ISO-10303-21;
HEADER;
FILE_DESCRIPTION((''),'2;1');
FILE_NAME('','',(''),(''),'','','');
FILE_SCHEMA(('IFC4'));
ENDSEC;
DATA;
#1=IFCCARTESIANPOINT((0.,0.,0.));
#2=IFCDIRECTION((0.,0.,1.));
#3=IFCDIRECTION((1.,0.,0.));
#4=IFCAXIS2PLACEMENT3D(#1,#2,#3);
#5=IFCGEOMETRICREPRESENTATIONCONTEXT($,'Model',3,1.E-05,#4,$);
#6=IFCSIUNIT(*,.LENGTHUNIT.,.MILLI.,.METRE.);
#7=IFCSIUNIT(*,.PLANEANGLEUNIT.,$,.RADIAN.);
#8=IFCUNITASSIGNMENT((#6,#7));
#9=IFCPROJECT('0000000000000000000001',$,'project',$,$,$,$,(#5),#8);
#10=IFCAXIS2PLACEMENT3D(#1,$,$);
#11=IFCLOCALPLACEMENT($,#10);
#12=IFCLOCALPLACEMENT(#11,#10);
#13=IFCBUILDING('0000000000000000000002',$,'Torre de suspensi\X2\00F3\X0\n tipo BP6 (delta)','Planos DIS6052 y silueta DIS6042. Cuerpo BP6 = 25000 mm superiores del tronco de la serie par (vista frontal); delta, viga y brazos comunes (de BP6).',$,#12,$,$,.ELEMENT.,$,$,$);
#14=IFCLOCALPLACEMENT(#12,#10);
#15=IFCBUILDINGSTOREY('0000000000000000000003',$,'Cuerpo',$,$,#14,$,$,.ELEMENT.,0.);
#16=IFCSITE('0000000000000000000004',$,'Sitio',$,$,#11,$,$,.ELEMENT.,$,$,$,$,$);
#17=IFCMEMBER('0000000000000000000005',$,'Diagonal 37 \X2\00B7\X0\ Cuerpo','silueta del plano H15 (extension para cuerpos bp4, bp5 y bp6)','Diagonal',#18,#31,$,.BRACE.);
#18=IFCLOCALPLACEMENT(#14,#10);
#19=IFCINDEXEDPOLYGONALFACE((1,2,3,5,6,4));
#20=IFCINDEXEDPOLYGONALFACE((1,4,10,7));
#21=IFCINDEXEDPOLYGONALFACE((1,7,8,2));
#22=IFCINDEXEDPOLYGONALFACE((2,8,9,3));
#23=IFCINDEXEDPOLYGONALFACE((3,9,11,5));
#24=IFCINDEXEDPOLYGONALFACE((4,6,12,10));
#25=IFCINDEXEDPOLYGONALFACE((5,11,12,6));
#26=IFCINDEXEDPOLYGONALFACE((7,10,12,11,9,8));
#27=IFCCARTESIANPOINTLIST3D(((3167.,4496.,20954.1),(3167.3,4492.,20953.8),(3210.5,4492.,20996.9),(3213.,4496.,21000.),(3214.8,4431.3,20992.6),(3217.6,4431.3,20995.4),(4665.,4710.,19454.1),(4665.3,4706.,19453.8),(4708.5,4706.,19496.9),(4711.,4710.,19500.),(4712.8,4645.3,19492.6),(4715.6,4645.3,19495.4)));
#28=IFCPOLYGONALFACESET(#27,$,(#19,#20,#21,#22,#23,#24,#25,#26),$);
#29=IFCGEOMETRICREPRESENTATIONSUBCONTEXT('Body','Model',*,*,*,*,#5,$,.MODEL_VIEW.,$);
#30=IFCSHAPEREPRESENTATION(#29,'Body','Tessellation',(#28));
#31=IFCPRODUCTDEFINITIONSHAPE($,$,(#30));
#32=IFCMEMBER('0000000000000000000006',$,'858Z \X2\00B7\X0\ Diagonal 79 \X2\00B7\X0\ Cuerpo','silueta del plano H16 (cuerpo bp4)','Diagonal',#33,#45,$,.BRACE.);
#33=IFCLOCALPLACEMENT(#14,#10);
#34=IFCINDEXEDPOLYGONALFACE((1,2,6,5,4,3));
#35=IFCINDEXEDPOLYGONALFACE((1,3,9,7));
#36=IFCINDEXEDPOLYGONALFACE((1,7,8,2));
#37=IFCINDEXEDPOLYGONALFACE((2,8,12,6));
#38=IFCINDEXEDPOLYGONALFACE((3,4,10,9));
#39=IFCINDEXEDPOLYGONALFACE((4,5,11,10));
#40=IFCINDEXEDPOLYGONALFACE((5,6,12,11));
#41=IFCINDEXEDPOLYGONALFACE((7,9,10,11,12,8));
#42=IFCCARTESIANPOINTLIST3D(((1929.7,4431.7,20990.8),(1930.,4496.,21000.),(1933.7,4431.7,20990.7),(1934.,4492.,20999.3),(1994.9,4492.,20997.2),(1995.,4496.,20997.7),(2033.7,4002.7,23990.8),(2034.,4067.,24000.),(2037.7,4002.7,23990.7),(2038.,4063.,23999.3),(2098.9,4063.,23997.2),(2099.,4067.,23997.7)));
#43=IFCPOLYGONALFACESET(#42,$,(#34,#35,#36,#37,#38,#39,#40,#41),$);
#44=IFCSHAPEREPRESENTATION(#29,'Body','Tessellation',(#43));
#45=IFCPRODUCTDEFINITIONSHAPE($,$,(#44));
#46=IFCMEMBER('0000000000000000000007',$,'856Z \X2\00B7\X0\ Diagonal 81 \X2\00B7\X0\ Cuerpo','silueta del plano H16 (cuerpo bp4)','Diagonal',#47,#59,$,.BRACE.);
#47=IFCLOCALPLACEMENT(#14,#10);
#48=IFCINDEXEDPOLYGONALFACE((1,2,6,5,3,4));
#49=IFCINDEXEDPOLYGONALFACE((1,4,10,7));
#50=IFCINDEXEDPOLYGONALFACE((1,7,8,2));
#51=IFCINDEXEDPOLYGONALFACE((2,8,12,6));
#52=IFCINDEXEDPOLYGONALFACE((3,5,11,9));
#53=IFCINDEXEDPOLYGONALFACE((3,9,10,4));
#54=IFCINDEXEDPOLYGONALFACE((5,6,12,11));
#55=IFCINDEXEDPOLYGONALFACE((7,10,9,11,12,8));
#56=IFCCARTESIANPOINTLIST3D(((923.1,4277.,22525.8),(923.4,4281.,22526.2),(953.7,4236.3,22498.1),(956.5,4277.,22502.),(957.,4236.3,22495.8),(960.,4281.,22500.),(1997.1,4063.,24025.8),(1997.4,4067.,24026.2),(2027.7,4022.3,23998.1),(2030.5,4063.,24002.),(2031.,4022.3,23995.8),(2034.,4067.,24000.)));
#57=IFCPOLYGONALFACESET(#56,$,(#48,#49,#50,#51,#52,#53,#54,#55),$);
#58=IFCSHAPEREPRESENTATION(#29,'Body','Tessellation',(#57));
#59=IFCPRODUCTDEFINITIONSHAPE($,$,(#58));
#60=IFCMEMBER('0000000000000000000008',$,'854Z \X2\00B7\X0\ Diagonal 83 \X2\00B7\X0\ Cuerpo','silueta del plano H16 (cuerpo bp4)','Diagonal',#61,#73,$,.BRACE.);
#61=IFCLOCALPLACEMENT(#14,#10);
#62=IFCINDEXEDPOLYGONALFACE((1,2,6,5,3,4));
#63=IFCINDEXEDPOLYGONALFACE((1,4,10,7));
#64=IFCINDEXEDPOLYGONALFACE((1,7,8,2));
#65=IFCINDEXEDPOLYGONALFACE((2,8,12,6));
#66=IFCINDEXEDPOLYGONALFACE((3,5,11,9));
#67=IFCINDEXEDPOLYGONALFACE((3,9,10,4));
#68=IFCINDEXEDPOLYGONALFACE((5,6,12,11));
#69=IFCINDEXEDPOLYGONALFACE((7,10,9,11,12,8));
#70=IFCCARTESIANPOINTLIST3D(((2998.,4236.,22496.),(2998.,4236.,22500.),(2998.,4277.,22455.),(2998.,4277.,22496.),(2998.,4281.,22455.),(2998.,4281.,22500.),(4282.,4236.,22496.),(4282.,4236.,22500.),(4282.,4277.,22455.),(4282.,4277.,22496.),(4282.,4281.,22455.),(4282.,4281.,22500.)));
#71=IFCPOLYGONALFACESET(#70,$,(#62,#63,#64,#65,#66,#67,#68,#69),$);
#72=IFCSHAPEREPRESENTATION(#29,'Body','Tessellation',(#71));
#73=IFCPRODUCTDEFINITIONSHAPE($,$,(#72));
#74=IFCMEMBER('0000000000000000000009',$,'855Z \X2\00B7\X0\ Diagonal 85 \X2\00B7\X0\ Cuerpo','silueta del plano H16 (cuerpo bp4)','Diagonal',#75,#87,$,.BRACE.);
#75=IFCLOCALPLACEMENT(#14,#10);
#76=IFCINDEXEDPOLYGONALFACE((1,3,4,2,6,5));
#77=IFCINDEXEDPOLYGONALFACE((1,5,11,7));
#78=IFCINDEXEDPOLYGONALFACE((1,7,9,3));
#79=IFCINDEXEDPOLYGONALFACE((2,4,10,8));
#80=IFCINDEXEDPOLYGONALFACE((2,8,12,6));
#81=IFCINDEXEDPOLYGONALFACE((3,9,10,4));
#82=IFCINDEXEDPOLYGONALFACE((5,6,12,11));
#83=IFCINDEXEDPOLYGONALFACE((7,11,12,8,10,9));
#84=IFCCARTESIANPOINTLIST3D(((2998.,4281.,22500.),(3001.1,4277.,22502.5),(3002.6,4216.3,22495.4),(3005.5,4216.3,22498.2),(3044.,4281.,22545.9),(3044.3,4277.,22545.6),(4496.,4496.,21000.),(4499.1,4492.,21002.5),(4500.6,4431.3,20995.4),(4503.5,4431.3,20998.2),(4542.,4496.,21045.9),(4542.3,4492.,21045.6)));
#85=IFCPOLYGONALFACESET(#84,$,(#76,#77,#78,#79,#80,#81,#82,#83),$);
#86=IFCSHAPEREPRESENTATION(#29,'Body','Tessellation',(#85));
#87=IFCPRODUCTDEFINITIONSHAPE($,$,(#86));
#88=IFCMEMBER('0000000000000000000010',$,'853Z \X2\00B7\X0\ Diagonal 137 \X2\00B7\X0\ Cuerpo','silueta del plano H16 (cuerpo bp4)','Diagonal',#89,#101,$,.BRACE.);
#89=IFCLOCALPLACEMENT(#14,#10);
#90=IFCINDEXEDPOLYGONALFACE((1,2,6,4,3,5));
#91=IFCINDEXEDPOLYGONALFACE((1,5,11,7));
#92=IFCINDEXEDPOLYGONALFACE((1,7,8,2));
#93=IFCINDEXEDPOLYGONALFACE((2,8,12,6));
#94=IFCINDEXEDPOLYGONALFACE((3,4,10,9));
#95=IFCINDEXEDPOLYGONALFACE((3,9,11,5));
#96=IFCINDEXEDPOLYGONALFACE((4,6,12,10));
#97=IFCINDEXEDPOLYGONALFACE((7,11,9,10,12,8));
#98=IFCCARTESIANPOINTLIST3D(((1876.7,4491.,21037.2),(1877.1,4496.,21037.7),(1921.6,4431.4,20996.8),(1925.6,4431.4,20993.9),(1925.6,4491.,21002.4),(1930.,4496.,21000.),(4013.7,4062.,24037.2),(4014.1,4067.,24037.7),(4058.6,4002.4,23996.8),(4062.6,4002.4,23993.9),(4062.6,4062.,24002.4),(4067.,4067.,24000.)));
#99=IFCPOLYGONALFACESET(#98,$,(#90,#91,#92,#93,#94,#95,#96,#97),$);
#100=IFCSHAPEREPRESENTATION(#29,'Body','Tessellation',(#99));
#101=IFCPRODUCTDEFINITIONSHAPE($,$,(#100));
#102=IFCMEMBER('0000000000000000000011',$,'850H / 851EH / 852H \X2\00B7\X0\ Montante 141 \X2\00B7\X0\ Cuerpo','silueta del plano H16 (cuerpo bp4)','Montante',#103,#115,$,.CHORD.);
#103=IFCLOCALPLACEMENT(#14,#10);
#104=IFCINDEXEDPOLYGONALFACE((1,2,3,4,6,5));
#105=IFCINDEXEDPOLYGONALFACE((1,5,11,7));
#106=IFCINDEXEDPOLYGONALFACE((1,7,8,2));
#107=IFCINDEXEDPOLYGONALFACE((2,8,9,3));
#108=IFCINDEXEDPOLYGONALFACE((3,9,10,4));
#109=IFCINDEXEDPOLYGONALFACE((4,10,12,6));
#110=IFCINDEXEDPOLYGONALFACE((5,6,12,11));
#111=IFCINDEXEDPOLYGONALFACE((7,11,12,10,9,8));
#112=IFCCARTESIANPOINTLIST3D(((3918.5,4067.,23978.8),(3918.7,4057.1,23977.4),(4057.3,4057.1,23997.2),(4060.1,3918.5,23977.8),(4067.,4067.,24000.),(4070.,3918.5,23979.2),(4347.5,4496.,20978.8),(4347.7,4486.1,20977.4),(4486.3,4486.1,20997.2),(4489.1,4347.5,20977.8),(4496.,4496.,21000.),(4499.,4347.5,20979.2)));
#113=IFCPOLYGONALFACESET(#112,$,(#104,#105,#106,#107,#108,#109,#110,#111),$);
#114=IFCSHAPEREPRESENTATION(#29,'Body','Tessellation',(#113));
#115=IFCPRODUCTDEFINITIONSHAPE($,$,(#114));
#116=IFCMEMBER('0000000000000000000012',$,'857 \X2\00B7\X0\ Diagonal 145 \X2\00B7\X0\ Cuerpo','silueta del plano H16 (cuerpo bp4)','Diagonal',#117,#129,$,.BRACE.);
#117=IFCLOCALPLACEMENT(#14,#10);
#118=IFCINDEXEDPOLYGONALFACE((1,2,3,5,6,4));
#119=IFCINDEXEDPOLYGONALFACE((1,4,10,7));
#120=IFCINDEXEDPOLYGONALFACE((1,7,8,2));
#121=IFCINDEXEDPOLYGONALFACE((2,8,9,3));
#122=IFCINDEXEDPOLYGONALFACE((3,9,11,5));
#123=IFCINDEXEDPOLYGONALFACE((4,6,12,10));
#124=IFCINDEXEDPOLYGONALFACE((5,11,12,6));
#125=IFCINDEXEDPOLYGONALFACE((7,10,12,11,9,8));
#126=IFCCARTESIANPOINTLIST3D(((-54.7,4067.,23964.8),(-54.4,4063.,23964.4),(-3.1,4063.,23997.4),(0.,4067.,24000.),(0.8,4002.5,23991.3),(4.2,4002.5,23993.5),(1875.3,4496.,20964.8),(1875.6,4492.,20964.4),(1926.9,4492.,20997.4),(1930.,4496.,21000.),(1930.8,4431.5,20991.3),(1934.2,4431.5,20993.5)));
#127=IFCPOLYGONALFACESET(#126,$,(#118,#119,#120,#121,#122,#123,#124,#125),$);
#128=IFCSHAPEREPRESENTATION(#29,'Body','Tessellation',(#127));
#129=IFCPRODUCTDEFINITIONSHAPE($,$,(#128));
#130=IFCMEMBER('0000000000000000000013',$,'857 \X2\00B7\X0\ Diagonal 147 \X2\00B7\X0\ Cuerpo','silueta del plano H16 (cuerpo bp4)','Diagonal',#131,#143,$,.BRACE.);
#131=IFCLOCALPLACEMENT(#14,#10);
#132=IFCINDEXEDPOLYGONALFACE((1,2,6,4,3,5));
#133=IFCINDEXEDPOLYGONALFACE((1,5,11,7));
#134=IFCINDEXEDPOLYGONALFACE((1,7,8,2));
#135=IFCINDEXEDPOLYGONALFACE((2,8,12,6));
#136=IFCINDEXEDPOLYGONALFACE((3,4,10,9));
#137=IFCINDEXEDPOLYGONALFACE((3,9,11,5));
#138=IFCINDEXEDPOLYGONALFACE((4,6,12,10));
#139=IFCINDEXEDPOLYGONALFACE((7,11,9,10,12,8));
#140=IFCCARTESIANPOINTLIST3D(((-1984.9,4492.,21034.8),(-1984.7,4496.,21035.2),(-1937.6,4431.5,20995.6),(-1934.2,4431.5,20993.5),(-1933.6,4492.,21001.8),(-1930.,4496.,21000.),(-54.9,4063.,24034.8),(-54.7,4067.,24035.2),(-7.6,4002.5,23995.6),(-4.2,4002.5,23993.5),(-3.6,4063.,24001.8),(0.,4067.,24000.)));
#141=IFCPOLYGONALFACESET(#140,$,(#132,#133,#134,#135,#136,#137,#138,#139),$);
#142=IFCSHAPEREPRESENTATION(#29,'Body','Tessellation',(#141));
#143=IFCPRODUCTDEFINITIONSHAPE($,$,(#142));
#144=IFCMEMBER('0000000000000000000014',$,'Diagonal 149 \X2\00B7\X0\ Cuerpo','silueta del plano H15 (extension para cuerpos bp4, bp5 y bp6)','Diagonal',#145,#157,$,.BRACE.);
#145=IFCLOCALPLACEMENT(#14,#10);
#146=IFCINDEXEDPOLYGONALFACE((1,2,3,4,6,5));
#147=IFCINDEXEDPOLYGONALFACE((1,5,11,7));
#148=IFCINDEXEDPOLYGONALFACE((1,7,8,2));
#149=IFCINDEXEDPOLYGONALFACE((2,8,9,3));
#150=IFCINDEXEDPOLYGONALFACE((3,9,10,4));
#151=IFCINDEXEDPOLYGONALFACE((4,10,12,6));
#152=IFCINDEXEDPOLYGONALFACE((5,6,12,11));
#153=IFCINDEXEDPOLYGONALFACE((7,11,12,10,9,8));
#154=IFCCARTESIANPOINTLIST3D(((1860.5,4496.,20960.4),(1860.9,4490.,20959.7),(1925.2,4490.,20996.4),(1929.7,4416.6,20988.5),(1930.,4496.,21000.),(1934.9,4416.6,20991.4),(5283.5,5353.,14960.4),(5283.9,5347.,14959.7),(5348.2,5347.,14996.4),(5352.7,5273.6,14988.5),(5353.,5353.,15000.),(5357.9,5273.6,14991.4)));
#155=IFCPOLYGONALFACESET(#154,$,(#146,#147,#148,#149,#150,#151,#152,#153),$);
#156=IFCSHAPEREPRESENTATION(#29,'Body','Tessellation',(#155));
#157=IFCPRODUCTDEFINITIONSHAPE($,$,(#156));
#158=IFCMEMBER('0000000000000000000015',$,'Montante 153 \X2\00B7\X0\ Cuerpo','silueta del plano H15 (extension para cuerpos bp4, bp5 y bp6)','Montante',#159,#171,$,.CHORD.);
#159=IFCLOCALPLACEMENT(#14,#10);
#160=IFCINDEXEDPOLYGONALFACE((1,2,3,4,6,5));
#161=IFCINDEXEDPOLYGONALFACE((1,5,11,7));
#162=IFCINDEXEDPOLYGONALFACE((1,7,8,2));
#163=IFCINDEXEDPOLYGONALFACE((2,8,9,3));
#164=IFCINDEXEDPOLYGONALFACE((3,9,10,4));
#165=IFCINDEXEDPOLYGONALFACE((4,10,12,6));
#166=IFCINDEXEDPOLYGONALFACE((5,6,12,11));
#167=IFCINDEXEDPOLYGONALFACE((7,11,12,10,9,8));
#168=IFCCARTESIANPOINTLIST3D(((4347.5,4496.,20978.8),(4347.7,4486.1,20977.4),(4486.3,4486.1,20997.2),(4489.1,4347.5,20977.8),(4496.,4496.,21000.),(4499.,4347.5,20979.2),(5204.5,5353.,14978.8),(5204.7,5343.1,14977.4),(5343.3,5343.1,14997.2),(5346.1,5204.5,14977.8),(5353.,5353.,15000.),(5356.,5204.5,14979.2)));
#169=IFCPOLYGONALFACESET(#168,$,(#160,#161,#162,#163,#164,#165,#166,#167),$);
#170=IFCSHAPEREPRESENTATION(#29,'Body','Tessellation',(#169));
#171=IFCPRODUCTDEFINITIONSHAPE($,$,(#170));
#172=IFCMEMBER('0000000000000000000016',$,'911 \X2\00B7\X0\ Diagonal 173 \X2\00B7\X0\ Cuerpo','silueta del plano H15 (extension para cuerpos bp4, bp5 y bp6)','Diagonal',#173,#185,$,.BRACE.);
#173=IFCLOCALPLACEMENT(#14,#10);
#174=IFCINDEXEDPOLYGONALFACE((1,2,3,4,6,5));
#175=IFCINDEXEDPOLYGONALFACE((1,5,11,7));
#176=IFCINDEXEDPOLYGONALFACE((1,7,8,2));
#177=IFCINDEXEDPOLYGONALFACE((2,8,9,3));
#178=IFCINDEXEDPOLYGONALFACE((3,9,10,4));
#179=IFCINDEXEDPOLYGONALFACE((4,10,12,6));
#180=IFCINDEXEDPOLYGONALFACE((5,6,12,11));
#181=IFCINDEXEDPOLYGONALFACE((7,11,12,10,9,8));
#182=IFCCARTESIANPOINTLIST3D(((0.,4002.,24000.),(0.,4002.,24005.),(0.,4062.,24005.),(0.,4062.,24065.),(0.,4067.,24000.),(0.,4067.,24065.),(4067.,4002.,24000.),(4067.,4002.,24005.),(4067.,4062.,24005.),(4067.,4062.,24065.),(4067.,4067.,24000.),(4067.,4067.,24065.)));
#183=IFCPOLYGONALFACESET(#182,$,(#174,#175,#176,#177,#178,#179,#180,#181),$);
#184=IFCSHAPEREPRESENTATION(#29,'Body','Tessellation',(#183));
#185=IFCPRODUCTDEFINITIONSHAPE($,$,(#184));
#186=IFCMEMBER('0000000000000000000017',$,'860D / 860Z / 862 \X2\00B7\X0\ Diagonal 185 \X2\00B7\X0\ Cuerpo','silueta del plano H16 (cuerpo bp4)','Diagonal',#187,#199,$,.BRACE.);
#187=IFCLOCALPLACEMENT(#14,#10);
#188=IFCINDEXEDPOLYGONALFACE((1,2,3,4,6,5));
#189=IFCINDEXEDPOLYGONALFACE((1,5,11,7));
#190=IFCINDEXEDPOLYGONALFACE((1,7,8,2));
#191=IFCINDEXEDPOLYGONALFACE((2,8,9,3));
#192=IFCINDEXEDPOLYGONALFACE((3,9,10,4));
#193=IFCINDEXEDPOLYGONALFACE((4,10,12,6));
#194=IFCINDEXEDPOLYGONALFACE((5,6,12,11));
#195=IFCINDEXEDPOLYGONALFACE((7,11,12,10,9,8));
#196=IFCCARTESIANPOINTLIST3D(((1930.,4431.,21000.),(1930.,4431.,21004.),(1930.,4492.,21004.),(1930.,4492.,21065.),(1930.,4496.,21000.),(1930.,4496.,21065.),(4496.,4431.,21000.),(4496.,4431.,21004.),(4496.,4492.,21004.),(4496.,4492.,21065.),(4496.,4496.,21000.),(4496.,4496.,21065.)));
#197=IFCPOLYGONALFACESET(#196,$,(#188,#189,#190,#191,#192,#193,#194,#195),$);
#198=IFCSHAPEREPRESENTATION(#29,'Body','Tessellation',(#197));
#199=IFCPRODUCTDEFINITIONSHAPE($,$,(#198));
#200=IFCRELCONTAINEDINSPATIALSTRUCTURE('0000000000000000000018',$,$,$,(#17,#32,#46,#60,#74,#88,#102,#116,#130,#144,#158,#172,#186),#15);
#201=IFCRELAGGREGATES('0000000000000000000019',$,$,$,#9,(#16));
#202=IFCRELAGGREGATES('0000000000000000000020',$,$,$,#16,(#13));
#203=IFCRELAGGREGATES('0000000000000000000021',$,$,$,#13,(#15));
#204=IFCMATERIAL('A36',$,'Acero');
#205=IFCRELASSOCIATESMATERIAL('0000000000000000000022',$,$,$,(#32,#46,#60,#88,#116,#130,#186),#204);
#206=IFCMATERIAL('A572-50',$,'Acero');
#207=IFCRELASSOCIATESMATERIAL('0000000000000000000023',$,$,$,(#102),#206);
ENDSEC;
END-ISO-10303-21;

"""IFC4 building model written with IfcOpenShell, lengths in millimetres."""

from ifc_helpers import new_model, si_unit, frame, frame_2d, origin, origin_with_axes, place, context, subcontext, project, spatial, l_section, extrude, material, element, save


model = new_model("IFC4")

# Units and contexts
model_context = context("Model", 3, precision=1e-05, world=origin_with_axes())
body_context = subcontext(model_context, "Body", "Model", "MODEL_VIEW")
ifc_project = project(units=[si_unit("LENGTHUNIT", "METRE", prefix="MILLI"), si_unit("PLANEANGLEUNIT", "RADIAN")], contexts=[model_context])

# Site, building, storey
site_placement = place(None, origin())
site = spatial("IfcSite", under=ifc_project, at=site_placement, Name="Sitio", CompositionType="ELEMENT")
building_placement = place(site_placement, origin())
building = spatial("IfcBuilding", under=site, at=building_placement, Name="Torre de suspensión tipo BP6 (delta)", Description="Planos DIS6052 y silueta DIS6042. Cuerpo BP6 = 25000 mm superiores del tronco de la serie par (vista frontal); delta, viga y brazos comunes (de BP6).", CompositionType="ELEMENT")
storey_placement = place(building_placement, origin())
storey = spatial("IfcBuildingStorey", under=building, at=storey_placement, Name="Cuerpo", CompositionType="ELEMENT", Elevation=0.0)

# Members
member_1_placement = place(storey_placement, frame((3213.0, 4496.0, 21000.0), z_axis=(0.703062, 0.100437, -0.704), x_axis=(0.070973, -0.994943, -0.071067)))
element("IfcMember", 1, at=member_1_placement, inside=storey, Name="Diagonal 37 · Cuerpo", Description="silueta del plano H15 (extension para cuerpos bp4, bp5 y bp6)", ObjectType="Diagonal", PredefinedType="BRACE", context=body_context, shape_type="SweptSolid", body=[
    extrude(l_section(Depth=65.0, Width=65.0, Thickness=4.0, at=frame_2d((32.5, 32.5))), None, (0.0, 0.0, 1.0), 2130.7),
])
ifc_material_1 = material(Name="A36", Category="Acero")
member_2_placement = place(storey_placement, frame((1930.0, 4496.0, 21000.0), z_axis=(0.034297, -0.141477, 0.989347), x_axis=(-0.004902, -0.989942, -0.141392)))
element("IfcMember", 2, at=member_2_placement, inside=storey, material=ifc_material_1, Name="858Z · Diagonal 79 · Cuerpo", Description="silueta del plano H16 (cuerpo bp4)", ObjectType="Diagonal", PredefinedType="BRACE", context=body_context, shape_type="SweptSolid", body=[
    extrude(l_section(Depth=65.0, Width=65.0, Thickness=4.0, at=frame_2d((32.5, 32.5))), None, (0.0, 0.0, 1.0), 3032.3),
])
member_3_placement = place(storey_placement, frame((2034.0, 4067.0, 24000.0), z_axis=(-0.578283, 0.115226, -0.807658), x_axis=(-0.06708, -0.993339, -0.093687)))
element("IfcMember", 3, at=member_3_placement, inside=storey, material=ifc_material_1, Name="856Z · Diagonal 81 · Cuerpo", Description="silueta del plano H16 (cuerpo bp4)", ObjectType="Diagonal", PredefinedType="BRACE", context=body_context, shape_type="SweptSolid", body=[
    extrude(l_section(Depth=45.0, Width=45.0, Thickness=4.0, at=frame_2d((22.5, 22.5))), None, (0.0, 0.0, 1.0), 1857.2),
])
member_4_placement = place(storey_placement, frame((2998.0, 4281.0, 22500.0), z_axis=(1.0, 0.0, 0.0), x_axis=(0.0, -1.0, 0.0)))
element("IfcMember", 4, at=member_4_placement, inside=storey, material=ifc_material_1, Name="854Z · Diagonal 83 · Cuerpo", Description="silueta del plano H16 (cuerpo bp4)", ObjectType="Diagonal", PredefinedType="BRACE", context=body_context, shape_type="SweptSolid", body=[
    extrude(l_section(Depth=45.0, Width=45.0, Thickness=4.0, at=frame_2d((22.5, 22.5))), None, (0.0, 0.0, 1.0), 1284.0),
])
member_5_placement = place(storey_placement, frame((4496.0, 4496.0, 21000.0), z_axis=(-0.703029, -0.100902, 0.703967), x_axis=(0.071301, -0.994896, -0.071396)))
element("IfcMember", 5, at=member_5_placement, inside=storey, Name="855Z · Diagonal 85 · Cuerpo", Description="silueta del plano H16 (cuerpo bp4)", ObjectType="Diagonal", PredefinedType="BRACE", context=body_context, shape_type="SweptSolid", body=[
    extrude(l_section(Depth=65.0, Width=65.0, Thickness=4.0, at=frame_2d((32.5, 32.5))), None, (0.0, 0.0, 1.0), 2130.8),
])
member_6_placement = place(storey_placement, frame((4067.0, 4067.0, 24000.0), z_axis=(-0.576289, 0.115689, -0.809016), x_axis=(-0.067121, -0.993285, -0.094227)))
element("IfcMember", 6, at=member_6_placement, inside=storey, material=ifc_material_1, Name="853Z · Diagonal 137 · Cuerpo", Description="silueta del plano H16 (cuerpo bp4)", ObjectType="Diagonal", PredefinedType="BRACE", context=body_context, shape_type="SweptSolid", body=[
    extrude(l_section(Depth=65.0, Width=65.0, Thickness=5.0, at=frame_2d((32.5, 32.5))), None, (0.0, 0.0, 1.0), 3708.2),
])
ifc_material_2 = material(Name="A572-50", Category="Acero")
member_7_placement = place(storey_placement, frame((4067.0, 4067.0, 24000.0), z_axis=(0.140163, 0.140163, -0.980158), x_axis=(0.019841, -0.990129, -0.138751)))
element("IfcMember", 7, at=member_7_placement, inside=storey, material=ifc_material_2, Name="850H / 851EH / 852H · Montante 141 · Cuerpo", Description="silueta del plano H16 (cuerpo bp4)", ObjectType="Montante", PredefinedType="CHORD", context=body_context, shape_type="SweptSolid", body=[
    extrude(l_section(Depth=150.0, Width=150.0, Thickness=10.0, at=frame_2d((75.0, 75.0))), None, (0.0, 0.0, 1.0), 3060.7),
])
for number, where, z_axis, x_axis, name in (
    (8, (0.0, 4067.0, 24000.0), (0.53717, 0.119402, -0.83498), (0.064601, -0.992846, -0.100417), "857 · Diagonal 145 · Cuerpo"),
    (9, (0.0, 4067.0, 24000.0), (-0.53717, 0.119402, -0.83498), (-0.064601, -0.992846, -0.100417), "857 · Diagonal 147 · Cuerpo"),
):
    element("IfcMember", number, at=place(storey_placement, frame(where, z_axis=z_axis, x_axis=x_axis)), inside=storey, material=ifc_material_1, Name=name, Description="silueta del plano H16 (cuerpo bp4)", ObjectType="Diagonal", PredefinedType="BRACE", context=body_context, shape_type="SweptSolid", body=[
        extrude(l_section(Depth=65.0, Width=65.0, Thickness=4.0, at=frame_2d((32.5, 32.5))), None, (0.0, 0.0, 1.0), 3592.9),
    ])
member_8_placement = place(storey_placement, frame((1930.0, 4496.0, 21000.0), z_axis=(0.491761, 0.12312, -0.861982), x_axis=(0.06101, -0.992392, -0.106941)))
element("IfcMember", 10, at=member_8_placement, inside=storey, Name="Diagonal 149 · Cuerpo", Description="silueta del plano H15 (extension para cuerpos bp4, bp5 y bp6)", ObjectType="Diagonal", PredefinedType="BRACE", context=body_context, shape_type="SweptSolid", body=[
    extrude(l_section(Depth=80.0, Width=80.0, Thickness=6.0, at=frame_2d((40.0, 40.0))), None, (0.0, 0.0, 1.0), 6960.7),
])
member_9_placement = place(storey_placement, frame((4496.0, 4496.0, 21000.0), z_axis=(0.140006, 0.140006, -0.980202), x_axis=(0.019797, -0.990151, -0.138599)))
element("IfcMember", 11, at=member_9_placement, inside=storey, Name="Montante 153 · Cuerpo", Description="silueta del plano H15 (extension para cuerpos bp4, bp5 y bp6)", ObjectType="Montante", PredefinedType="CHORD", context=body_context, shape_type="SweptSolid", body=[
    extrude(l_section(Depth=150.0, Width=150.0, Thickness=10.0, at=frame_2d((75.0, 75.0))), None, (0.0, 0.0, 1.0), 6121.2),
])
member_10_placement = place(storey_placement, frame((4067.0, 4067.0, 24000.0), z_axis=(-1.0, 0.0, 0.0), x_axis=(0.0, -1.0, 0.0)))
element("IfcMember", 12, at=member_10_placement, inside=storey, Name="911 · Diagonal 173 · Cuerpo", Description="silueta del plano H15 (extension para cuerpos bp4, bp5 y bp6)", ObjectType="Diagonal", PredefinedType="BRACE", context=body_context, shape_type="SweptSolid", body=[
    extrude(l_section(Depth=65.0, Width=65.0, Thickness=5.0, at=frame_2d((32.5, 32.5))), None, (0.0, 0.0, 1.0), 4067.0),
])
member_11_placement = place(storey_placement, frame((4496.0, 4496.0, 21000.0), z_axis=(-1.0, 0.0, 0.0), x_axis=(0.0, -1.0, 0.0)))
element("IfcMember", 13, at=member_11_placement, inside=storey, material=ifc_material_1, Name="860D / 860Z / 862 · Diagonal 185 · Cuerpo", Description="silueta del plano H16 (cuerpo bp4)", ObjectType="Diagonal", PredefinedType="BRACE", context=body_context, shape_type="SweptSolid", body=[
    extrude(l_section(Depth=65.0, Width=65.0, Thickness=4.0, at=frame_2d((32.5, 32.5))), None, (0.0, 0.0, 1.0), 2566.0),
])

save(model, "model.ifc")
